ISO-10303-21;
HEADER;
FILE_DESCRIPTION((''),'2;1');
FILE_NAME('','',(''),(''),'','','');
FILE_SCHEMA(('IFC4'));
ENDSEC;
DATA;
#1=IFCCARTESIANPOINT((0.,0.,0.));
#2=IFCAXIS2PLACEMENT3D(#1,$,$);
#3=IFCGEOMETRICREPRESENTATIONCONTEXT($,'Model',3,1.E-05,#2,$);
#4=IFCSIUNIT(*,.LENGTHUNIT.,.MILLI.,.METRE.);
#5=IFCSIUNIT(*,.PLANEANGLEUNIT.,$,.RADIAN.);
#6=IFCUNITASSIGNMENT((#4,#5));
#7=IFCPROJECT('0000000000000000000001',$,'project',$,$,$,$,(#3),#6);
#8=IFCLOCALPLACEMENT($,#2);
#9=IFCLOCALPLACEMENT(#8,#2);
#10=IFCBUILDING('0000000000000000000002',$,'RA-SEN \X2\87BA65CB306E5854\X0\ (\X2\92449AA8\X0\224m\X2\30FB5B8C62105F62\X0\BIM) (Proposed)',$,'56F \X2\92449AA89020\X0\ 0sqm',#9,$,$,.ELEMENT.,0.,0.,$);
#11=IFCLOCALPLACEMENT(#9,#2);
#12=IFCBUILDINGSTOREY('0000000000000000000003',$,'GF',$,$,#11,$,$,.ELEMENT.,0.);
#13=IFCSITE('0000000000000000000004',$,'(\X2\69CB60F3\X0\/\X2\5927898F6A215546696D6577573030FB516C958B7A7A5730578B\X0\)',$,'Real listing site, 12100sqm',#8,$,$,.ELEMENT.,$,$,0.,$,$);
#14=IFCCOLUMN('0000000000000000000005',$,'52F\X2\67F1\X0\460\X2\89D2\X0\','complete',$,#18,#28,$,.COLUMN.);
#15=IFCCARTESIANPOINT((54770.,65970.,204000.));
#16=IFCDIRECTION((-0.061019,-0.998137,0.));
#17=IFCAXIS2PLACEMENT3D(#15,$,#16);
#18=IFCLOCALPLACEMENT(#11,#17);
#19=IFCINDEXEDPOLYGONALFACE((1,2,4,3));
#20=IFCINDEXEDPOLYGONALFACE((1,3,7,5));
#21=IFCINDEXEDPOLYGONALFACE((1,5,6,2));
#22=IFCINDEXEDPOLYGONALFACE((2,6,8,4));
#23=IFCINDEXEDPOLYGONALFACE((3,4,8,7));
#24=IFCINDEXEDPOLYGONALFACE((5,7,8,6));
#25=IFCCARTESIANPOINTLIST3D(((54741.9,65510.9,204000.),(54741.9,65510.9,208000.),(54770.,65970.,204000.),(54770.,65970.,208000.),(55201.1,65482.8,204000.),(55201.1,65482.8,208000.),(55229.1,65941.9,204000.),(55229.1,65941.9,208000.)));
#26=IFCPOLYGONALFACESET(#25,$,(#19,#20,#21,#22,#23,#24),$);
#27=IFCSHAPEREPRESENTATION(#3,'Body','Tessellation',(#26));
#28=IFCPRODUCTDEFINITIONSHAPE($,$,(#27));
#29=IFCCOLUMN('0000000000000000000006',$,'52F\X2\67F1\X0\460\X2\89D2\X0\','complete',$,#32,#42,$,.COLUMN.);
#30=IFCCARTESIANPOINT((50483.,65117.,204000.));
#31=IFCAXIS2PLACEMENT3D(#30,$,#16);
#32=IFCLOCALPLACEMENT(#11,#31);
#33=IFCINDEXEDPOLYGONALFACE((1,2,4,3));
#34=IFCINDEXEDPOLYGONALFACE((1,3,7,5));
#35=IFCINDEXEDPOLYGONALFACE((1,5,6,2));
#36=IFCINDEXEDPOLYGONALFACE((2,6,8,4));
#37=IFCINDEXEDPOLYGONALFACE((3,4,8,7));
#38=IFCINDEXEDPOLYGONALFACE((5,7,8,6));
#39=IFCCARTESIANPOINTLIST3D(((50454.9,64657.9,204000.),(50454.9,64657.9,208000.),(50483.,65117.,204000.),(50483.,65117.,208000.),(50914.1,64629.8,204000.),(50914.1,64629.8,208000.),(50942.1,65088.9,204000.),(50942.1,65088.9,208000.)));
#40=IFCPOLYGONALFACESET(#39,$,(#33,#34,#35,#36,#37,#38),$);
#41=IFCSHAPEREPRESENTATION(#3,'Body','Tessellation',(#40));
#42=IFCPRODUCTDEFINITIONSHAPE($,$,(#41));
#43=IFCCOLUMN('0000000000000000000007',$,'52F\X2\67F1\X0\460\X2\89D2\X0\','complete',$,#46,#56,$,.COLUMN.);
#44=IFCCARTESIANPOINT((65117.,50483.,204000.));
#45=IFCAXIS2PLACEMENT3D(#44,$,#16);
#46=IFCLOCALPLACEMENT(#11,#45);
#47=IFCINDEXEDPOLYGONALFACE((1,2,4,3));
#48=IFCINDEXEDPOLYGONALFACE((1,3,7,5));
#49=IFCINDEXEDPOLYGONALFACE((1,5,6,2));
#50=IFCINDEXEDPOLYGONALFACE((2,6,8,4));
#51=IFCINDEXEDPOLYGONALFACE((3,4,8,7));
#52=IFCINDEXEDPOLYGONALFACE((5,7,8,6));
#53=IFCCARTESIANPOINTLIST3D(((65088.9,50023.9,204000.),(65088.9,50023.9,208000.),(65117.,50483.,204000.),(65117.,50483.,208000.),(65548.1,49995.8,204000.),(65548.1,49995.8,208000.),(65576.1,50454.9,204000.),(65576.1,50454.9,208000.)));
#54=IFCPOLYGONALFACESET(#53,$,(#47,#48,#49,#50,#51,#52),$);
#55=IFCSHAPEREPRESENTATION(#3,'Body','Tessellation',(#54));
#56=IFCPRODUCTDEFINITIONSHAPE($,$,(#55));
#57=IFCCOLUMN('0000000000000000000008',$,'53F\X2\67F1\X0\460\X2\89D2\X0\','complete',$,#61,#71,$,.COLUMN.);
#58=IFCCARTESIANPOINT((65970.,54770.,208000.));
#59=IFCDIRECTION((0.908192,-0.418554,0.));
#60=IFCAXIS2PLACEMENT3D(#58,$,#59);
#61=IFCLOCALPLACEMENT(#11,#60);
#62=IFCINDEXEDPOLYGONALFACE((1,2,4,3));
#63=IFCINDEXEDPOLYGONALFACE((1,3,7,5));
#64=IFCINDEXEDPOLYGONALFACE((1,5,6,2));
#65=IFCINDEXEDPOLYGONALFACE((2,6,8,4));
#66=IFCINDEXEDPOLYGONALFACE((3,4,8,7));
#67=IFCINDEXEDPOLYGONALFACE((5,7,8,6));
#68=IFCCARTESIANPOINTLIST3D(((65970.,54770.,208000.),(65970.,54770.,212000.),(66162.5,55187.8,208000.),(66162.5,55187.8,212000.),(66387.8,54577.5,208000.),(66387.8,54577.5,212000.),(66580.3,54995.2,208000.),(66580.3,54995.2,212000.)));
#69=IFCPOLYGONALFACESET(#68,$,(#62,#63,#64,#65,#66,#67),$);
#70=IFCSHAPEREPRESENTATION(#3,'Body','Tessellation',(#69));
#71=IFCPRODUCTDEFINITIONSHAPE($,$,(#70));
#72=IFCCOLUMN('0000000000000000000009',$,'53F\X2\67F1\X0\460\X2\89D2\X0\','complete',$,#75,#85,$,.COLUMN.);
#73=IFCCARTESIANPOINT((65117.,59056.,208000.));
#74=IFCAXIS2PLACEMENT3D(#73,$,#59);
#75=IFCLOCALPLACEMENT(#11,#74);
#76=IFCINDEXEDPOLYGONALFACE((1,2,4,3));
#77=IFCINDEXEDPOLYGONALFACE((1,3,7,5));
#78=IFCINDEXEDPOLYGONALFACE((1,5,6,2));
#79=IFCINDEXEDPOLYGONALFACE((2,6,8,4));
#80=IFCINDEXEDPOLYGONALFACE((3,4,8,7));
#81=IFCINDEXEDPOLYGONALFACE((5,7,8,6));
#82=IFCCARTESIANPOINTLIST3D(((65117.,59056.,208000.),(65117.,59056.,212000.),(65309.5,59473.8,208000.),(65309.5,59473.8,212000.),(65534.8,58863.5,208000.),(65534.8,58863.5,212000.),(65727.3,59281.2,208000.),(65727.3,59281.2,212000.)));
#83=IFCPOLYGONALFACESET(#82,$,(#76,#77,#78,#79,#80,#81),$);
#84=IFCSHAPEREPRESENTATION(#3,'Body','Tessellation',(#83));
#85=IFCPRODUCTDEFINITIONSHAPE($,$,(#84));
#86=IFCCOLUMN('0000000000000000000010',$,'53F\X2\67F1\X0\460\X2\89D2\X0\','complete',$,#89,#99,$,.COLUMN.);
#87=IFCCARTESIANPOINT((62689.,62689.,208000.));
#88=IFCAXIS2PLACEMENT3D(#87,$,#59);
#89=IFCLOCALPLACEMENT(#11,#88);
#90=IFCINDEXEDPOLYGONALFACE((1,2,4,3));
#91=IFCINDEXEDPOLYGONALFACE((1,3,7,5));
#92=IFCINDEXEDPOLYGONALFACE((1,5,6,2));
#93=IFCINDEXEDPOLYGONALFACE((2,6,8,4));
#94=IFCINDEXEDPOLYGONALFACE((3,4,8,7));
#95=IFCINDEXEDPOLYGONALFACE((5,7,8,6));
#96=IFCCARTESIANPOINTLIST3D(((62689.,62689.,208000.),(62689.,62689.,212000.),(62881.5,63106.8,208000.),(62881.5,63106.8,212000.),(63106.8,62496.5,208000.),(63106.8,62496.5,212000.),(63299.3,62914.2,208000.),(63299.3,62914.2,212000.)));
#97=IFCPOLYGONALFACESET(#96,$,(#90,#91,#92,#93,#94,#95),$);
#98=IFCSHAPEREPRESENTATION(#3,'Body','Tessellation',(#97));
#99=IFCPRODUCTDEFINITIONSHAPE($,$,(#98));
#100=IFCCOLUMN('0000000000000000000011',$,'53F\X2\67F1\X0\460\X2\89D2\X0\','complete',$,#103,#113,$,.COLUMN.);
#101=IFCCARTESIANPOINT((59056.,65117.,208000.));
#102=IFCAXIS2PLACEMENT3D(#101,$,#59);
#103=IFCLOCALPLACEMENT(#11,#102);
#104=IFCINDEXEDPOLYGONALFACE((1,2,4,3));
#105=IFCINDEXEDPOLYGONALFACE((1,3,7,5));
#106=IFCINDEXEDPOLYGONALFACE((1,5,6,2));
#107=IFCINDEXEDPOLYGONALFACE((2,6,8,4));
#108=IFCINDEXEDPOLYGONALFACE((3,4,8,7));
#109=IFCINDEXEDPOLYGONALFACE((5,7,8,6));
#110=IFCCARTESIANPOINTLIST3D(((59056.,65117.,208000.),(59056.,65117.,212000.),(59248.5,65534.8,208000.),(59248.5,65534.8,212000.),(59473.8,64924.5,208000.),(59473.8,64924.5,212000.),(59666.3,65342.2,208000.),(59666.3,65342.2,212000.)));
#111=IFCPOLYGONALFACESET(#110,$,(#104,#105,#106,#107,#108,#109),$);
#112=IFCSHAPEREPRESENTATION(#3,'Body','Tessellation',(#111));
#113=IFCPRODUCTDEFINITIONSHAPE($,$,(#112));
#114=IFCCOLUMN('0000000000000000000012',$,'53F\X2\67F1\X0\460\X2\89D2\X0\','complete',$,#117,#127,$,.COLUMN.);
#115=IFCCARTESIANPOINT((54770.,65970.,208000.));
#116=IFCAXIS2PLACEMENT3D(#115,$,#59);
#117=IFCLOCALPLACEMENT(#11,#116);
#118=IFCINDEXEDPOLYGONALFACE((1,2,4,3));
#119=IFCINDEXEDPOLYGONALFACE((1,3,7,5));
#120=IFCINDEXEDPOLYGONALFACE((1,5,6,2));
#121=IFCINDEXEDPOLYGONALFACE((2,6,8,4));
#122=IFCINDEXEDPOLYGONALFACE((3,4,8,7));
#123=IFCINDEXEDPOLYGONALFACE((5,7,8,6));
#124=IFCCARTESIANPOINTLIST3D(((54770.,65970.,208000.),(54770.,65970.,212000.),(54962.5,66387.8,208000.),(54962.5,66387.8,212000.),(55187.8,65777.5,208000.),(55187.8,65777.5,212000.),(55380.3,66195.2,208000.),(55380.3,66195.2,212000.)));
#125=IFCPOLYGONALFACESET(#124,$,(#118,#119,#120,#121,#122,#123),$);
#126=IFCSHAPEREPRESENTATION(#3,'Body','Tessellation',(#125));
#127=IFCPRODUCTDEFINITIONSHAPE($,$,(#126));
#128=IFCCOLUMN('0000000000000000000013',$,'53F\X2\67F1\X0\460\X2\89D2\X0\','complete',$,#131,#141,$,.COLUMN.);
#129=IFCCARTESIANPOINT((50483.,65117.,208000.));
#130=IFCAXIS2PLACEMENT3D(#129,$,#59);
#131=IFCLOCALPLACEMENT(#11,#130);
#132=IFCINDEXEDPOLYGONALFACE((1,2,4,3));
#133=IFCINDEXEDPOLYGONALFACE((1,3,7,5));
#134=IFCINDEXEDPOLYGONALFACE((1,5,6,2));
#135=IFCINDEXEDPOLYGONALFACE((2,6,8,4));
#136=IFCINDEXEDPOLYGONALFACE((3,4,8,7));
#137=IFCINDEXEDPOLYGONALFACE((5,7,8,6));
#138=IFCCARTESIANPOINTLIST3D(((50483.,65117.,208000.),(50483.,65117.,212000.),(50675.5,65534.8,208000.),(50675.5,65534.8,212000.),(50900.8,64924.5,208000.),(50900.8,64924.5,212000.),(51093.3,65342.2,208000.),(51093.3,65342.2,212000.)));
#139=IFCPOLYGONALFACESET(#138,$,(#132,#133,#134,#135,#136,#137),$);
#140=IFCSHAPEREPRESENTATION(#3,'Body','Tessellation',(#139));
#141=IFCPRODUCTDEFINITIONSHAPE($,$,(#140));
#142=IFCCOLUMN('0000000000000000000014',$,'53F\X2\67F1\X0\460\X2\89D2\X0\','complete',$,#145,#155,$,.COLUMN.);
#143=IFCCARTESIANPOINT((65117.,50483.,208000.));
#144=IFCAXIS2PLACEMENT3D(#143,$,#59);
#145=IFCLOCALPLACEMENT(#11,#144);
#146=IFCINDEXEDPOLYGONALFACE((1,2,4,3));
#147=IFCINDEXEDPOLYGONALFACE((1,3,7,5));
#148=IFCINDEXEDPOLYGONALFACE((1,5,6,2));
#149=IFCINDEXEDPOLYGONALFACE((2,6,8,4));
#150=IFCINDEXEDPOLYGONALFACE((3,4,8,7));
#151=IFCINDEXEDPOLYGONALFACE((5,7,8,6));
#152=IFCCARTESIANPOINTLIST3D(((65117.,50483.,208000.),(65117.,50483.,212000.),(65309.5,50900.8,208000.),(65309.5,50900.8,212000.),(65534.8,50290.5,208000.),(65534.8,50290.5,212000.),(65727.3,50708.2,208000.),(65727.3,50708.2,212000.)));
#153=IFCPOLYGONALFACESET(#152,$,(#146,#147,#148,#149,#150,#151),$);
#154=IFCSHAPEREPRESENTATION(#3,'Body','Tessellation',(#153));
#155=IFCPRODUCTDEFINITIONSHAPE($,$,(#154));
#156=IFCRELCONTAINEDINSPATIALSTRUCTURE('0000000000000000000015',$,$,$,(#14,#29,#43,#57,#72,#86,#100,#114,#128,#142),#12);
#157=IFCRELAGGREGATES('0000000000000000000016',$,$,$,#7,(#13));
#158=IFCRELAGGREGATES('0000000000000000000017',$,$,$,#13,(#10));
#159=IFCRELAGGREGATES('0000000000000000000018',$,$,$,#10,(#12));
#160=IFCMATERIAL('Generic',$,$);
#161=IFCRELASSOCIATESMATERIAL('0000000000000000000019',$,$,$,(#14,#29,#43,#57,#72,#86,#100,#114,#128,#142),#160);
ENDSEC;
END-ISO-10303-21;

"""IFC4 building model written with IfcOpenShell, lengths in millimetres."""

from ifc_helpers import new_model, si_unit, frame, frame_2d, origin, place, context, project, spatial, rectangle, extrude, material, element, save


model = new_model("IFC4")

# Units and contexts
model_context = context("Model", 3, precision=1e-05, world=origin())
ifc_project = project(units=[si_unit("LENGTHUNIT", "METRE", prefix="MILLI"), si_unit("PLANEANGLEUNIT", "RADIAN")], contexts=[model_context])

# Site, building, storey
site_placement = place(None, origin())
site = spatial("IfcSite", under=ifc_project, at=site_placement, Name="(構想/大規模商業敷地・公開空地型)", ObjectType="Real listing site, 12100sqm", CompositionType="ELEMENT", RefElevation=0.0)
building_placement = place(site_placement, origin())
building = spatial("IfcBuilding", under=site, at=building_placement, Name="RA-SEN 螺旋の塔 (鉄骨224m・完成形BIM) (Proposed)", ObjectType="56F 鉄骨造 0sqm", CompositionType="ELEMENT", ElevationOfRefHeight=0.0, ElevationOfTerrain=0.0)
storey_placement = place(building_placement, origin())
storey = spatial("IfcBuildingStorey", under=building, at=storey_placement, Name="GF", CompositionType="ELEMENT", Elevation=0.0)

# Columns
ifc_material = material(Name="Generic")
column_1_placement = place(storey_placement, frame((54770.0, 65970.0, 204000.0), x_axis=(-0.061019, -0.998137, 0.0)))
element("IfcColumn", 1, at=column_1_placement, inside=storey, material=ifc_material, Name="52F柱460角", Description="complete", PredefinedType="COLUMN", context=model_context, shape_type="SweptSolid", body=[
    extrude(rectangle(XDim=460.0, YDim=460.0, at=frame_2d((230.0, 230.0))), frame((54770.0, 65970.0, 204000.0), x_axis=(-0.061019, -0.998137, 0.0)), (0.0, 0.0, 1.0), 4000.0),
])
column_2_placement = place(storey_placement, frame((50483.0, 65117.0, 204000.0), x_axis=(-0.061019, -0.998137, 0.0)))
element("IfcColumn", 2, at=column_2_placement, inside=storey, material=ifc_material, Name="52F柱460角", Description="complete", PredefinedType="COLUMN", context=model_context, shape_type="SweptSolid", body=[
    extrude(rectangle(XDim=460.0, YDim=460.0, at=frame_2d((230.0, 230.0))), frame((50483.0, 65117.0, 204000.0), x_axis=(-0.061019, -0.998137, 0.0)), (0.0, 0.0, 1.0), 4000.0),
])
column_3_placement = place(storey_placement, frame((65117.0, 50483.0, 204000.0), x_axis=(-0.061019, -0.998137, 0.0)))
element("IfcColumn", 3, at=column_3_placement, inside=storey, material=ifc_material, Name="52F柱460角", Description="complete", PredefinedType="COLUMN", context=model_context, shape_type="SweptSolid", body=[
    extrude(rectangle(XDim=460.0, YDim=460.0, at=frame_2d((230.0, 230.0))), frame((65117.0, 50483.0, 204000.0), x_axis=(-0.061019, -0.998137, 0.0)), (0.0, 0.0, 1.0), 4000.0),
])
column_4_placement = place(storey_placement, frame((65970.0, 54770.0, 208000.0), x_axis=(0.908192, -0.418554, 0.0)))
element("IfcColumn", 4, at=column_4_placement, inside=storey, material=ifc_material, Name="53F柱460角", Description="complete", PredefinedType="COLUMN", context=model_context, shape_type="SweptSolid", body=[
    extrude(rectangle(XDim=460.0, YDim=460.0, at=frame_2d((230.0, 230.0))), frame((65970.0, 54770.0, 208000.0), x_axis=(0.908192, -0.418554, 0.0)), (0.0, 0.0, 1.0), 4000.0),
])
column_5_placement = place(storey_placement, frame((65117.0, 59056.0, 208000.0), x_axis=(0.908192, -0.418554, 0.0)))
element("IfcColumn", 5, at=column_5_placement, inside=storey, material=ifc_material, Name="53F柱460角", Description="complete", PredefinedType="COLUMN", context=model_context, shape_type="SweptSolid", body=[
    extrude(rectangle(XDim=460.0, YDim=460.0, at=frame_2d((230.0, 230.0))), frame((65117.0, 59056.0, 208000.0), x_axis=(0.908192, -0.418554, 0.0)), (0.0, 0.0, 1.0), 4000.0),
])
column_6_placement = place(storey_placement, frame((62689.0, 62689.0, 208000.0), x_axis=(0.908192, -0.418554, 0.0)))
element("IfcColumn", 6, at=column_6_placement, inside=storey, material=ifc_material, Name="53F柱460角", Description="complete", PredefinedType="COLUMN", context=model_context, shape_type="SweptSolid", body=[
    extrude(rectangle(XDim=460.0, YDim=460.0, at=frame_2d((230.0, 230.0))), frame((62689.0, 62689.0, 208000.0), x_axis=(0.908192, -0.418554, 0.0)), (0.0, 0.0, 1.0), 4000.0),
])
column_7_placement = place(storey_placement, frame((59056.0, 65117.0, 208000.0), x_axis=(0.908192, -0.418554, 0.0)))
element("IfcColumn", 7, at=column_7_placement, inside=storey, material=ifc_material, Name="53F柱460角", Description="complete", PredefinedType="COLUMN", context=model_context, shape_type="SweptSolid", body=[
    extrude(rectangle(XDim=460.0, YDim=460.0, at=frame_2d((230.0, 230.0))), frame((59056.0, 65117.0, 208000.0), x_axis=(0.908192, -0.418554, 0.0)), (0.0, 0.0, 1.0), 4000.0),
])
column_8_placement = place(storey_placement, frame((54770.0, 65970.0, 208000.0), x_axis=(0.908192, -0.418554, 0.0)))
element("IfcColumn", 8, at=column_8_placement, inside=storey, material=ifc_material, Name="53F柱460角", Description="complete", PredefinedType="COLUMN", context=model_context, shape_type="SweptSolid", body=[
    extrude(rectangle(XDim=460.0, YDim=460.0, at=frame_2d((230.0, 230.0))), frame((54770.0, 65970.0, 208000.0), x_axis=(0.908192, -0.418554, 0.0)), (0.0, 0.0, 1.0), 4000.0),
])
column_9_placement = place(storey_placement, frame((50483.0, 65117.0, 208000.0), x_axis=(0.908192, -0.418554, 0.0)))
element("IfcColumn", 9, at=column_9_placement, inside=storey, material=ifc_material, Name="53F柱460角", Description="complete", PredefinedType="COLUMN", context=model_context, shape_type="SweptSolid", body=[
    extrude(rectangle(XDim=460.0, YDim=460.0, at=frame_2d((230.0, 230.0))), frame((50483.0, 65117.0, 208000.0), x_axis=(0.908192, -0.418554, 0.0)), (0.0, 0.0, 1.0), 4000.0),
])
column_10_placement = place(storey_placement, frame((65117.0, 50483.0, 208000.0), x_axis=(0.908192, -0.418554, 0.0)))
element("IfcColumn", 10, at=column_10_placement, inside=storey, material=ifc_material, Name="53F柱460角", Description="complete", PredefinedType="COLUMN", context=model_context, shape_type="SweptSolid", body=[
    extrude(rectangle(XDim=460.0, YDim=460.0, at=frame_2d((230.0, 230.0))), frame((65117.0, 50483.0, 208000.0), x_axis=(0.908192, -0.418554, 0.0)), (0.0, 0.0, 1.0), 4000.0),
])

save(model, "model.ifc")
